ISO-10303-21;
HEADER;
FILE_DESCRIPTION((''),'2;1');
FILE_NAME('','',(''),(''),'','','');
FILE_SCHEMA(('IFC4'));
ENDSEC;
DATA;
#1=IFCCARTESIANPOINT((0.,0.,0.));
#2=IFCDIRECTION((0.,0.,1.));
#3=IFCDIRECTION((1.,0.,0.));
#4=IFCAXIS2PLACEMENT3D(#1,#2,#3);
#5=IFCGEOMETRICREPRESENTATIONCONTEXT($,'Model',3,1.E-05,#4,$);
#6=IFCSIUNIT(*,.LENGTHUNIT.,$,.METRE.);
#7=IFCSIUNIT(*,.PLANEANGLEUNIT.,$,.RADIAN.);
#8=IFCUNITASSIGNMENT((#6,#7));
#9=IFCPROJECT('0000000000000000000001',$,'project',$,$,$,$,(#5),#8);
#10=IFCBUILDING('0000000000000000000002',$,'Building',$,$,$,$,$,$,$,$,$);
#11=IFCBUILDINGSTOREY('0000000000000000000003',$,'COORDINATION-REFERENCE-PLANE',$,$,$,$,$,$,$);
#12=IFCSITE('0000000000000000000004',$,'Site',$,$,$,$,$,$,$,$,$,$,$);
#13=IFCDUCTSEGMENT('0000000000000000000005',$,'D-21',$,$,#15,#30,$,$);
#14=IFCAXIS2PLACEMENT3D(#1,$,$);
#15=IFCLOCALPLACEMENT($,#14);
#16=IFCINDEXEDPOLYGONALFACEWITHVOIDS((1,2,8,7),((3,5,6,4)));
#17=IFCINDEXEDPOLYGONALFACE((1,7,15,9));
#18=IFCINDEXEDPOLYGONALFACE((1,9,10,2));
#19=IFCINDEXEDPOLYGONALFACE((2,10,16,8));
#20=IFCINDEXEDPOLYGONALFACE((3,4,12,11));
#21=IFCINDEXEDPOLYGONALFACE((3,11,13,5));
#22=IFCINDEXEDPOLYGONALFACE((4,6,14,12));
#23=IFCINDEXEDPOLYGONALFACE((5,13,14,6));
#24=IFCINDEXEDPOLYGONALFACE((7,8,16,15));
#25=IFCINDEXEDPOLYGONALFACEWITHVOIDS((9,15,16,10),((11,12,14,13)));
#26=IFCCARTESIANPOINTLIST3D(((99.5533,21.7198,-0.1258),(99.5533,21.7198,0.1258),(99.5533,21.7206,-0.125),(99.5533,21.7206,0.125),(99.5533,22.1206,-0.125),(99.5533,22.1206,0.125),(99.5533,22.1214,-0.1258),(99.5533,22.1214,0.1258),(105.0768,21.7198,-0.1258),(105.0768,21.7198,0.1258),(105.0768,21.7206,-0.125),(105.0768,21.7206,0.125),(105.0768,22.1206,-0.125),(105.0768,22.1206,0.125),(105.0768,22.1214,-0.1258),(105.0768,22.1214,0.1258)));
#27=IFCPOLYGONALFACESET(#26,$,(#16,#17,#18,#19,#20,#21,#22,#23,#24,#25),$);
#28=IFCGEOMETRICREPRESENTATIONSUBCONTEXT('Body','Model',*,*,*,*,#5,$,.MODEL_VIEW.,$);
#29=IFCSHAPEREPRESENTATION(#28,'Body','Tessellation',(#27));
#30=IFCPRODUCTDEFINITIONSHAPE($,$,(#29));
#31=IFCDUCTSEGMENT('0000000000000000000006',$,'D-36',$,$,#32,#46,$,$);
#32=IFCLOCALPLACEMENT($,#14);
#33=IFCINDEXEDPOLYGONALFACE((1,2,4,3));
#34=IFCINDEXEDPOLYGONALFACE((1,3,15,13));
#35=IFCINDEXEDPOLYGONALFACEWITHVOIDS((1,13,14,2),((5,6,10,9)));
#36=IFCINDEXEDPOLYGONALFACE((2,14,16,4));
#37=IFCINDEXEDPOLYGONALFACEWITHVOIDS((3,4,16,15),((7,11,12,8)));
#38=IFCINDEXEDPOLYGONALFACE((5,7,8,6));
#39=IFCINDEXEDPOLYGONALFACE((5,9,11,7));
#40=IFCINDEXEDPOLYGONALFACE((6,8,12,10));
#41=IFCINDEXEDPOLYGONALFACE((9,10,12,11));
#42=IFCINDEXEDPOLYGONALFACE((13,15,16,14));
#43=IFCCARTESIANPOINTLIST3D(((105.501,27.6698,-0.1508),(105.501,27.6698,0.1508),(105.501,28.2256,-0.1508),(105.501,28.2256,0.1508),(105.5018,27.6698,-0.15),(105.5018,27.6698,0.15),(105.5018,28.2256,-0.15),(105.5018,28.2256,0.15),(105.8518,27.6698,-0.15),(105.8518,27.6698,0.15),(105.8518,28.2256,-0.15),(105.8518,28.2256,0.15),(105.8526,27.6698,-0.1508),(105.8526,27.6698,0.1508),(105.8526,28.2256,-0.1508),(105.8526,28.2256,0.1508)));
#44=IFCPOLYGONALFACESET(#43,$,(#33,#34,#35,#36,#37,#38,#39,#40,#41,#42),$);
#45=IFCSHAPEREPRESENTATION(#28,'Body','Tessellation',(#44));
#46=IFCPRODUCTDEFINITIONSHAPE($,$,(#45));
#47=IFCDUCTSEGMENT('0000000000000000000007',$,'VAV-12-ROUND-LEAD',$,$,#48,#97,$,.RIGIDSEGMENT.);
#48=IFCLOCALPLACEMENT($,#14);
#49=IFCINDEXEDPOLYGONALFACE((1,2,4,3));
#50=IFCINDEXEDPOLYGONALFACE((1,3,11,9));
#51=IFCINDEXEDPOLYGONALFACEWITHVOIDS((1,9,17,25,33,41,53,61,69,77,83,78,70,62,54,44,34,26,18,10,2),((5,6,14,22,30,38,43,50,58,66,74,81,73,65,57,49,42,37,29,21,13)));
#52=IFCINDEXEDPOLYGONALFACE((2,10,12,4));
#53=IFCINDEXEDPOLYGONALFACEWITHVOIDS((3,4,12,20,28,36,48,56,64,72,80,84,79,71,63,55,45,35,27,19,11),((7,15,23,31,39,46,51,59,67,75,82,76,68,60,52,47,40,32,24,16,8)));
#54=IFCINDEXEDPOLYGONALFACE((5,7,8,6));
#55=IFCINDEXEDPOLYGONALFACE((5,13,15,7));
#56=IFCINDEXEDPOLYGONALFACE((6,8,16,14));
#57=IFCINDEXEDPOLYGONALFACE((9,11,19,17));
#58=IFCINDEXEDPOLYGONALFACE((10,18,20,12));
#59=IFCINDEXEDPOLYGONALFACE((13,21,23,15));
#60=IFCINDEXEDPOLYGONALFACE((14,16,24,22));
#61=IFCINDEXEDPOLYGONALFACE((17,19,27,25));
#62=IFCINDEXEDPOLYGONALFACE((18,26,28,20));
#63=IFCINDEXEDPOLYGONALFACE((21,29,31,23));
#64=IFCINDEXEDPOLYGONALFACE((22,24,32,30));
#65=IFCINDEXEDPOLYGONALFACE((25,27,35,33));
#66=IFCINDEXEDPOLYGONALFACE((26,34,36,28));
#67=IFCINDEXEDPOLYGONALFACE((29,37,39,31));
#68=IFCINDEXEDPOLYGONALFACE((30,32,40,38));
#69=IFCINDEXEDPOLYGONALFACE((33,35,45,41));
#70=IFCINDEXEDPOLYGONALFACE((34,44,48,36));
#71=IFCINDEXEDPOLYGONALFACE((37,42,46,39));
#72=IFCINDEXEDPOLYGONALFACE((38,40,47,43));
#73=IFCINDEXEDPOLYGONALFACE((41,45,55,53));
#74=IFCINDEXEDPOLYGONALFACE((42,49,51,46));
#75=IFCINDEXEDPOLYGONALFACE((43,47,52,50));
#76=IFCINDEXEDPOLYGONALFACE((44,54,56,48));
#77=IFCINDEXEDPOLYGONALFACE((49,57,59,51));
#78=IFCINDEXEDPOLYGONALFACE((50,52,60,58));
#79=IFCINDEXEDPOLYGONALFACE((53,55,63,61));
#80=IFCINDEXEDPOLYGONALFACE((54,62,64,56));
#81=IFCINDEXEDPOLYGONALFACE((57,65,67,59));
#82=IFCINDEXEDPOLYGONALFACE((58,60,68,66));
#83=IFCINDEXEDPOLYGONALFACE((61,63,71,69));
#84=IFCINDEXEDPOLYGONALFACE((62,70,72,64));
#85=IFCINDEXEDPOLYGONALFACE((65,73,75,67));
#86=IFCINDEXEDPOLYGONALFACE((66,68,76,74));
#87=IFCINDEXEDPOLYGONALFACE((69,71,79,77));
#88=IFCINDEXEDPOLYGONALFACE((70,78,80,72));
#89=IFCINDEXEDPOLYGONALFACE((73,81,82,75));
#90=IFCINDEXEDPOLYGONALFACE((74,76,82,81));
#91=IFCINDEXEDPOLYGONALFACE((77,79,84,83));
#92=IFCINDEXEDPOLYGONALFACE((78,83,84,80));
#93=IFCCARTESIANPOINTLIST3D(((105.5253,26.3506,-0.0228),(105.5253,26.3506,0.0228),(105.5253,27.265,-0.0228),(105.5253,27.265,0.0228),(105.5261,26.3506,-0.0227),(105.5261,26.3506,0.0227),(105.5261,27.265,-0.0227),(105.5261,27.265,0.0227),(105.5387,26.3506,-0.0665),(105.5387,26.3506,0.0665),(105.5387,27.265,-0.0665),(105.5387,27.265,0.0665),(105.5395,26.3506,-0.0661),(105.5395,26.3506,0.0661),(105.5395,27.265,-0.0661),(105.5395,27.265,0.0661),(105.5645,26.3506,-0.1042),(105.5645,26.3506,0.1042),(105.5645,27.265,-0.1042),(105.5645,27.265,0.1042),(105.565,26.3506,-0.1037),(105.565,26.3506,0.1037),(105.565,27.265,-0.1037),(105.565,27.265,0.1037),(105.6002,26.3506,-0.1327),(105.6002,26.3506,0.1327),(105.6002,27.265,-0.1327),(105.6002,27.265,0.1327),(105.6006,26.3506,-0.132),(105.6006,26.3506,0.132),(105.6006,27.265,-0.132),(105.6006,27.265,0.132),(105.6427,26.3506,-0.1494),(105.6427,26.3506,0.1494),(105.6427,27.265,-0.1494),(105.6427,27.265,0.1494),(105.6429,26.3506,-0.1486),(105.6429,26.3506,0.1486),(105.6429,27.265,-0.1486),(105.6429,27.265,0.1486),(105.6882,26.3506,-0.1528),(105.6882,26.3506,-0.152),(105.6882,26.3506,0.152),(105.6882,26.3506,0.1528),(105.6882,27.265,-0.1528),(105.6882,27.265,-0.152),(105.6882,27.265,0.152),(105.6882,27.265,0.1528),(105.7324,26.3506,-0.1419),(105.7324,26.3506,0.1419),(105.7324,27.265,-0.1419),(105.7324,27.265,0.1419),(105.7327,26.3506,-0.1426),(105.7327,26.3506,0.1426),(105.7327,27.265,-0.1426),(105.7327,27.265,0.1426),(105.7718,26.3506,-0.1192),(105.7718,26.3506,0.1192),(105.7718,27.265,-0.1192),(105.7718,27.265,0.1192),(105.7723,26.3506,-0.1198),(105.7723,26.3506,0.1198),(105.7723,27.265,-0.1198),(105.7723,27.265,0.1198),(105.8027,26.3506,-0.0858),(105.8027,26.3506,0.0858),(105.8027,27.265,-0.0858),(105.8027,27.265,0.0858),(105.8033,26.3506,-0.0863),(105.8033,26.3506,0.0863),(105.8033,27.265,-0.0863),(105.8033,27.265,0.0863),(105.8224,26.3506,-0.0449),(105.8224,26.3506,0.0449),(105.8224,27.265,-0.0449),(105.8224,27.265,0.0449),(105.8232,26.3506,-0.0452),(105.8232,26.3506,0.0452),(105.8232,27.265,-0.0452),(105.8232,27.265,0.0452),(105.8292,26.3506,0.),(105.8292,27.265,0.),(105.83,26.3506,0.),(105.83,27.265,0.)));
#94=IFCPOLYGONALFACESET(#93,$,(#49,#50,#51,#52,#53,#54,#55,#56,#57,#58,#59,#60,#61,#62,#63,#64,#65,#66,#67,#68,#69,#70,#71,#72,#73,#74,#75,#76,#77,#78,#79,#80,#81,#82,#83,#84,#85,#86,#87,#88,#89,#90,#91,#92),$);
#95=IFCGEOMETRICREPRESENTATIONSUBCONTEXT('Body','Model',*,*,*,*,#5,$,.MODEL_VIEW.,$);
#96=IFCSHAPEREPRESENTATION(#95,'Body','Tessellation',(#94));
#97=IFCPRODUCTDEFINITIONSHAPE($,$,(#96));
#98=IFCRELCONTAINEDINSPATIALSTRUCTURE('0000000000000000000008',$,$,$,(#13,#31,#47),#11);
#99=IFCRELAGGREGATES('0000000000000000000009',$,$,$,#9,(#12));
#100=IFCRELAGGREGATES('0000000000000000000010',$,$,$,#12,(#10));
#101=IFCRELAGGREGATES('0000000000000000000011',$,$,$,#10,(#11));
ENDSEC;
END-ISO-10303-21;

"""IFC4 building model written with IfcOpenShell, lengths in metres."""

from ifc_helpers import new_model, si_unit, frame, origin, origin_with_axes, place, context, subcontext, project, spatial, hollow_rectangle, hollow_circle, extrude, element, save


model = new_model("IFC4")

# Units and contexts
model_context = context("Model", 3, precision=1e-05, world=origin_with_axes())
body_context_1 = subcontext(model_context, "Body", "Model", "MODEL_VIEW")
body_context_2 = subcontext(model_context, "Body", "Model", "MODEL_VIEW")
ifc_project = project(units=[si_unit("LENGTHUNIT", "METRE"), si_unit("PLANEANGLEUNIT", "RADIAN")], contexts=[model_context])

# Site, building, storey
site = spatial("IfcSite", under=ifc_project, Name="Site")
building = spatial("IfcBuilding", under=site, Name="Building")
storey = spatial("IfcBuildingStorey", under=building, Name="COORDINATION-REFERENCE-PLANE")

# Duct segments
duct_segment_1_placement = place(None, frame((99.5533, 21.9206, 0.0), z_axis=(1.0, 0.0, 0.0), x_axis=(0.0, 1.0, 0.0)))
element("IfcDuctSegment", 1, at=duct_segment_1_placement, inside=storey, Name="D-21", context=body_context_1, shape_type="SweptSolid", body=[
    extrude(hollow_rectangle(XDim=0.4016, YDim=0.2516, WallThickness=0.0008), origin(), (0.0, 0.0, 1.0), 5.5234),
])
duct_segment_2_placement = place(None, frame((105.6768, 27.6698, 0.0), z_axis=(0.0, 1.0, 0.0), x_axis=(1.0, 0.0, 0.0)))
element("IfcDuctSegment", 2, at=duct_segment_2_placement, inside=storey, Name="D-36", context=body_context_1, shape_type="SweptSolid", body=[
    extrude(hollow_rectangle(XDim=0.3516, YDim=0.3016, WallThickness=0.0008), origin(), (0.0, 0.0, 1.0), 0.5558),
])
duct_segment_3_placement = place(None, frame((105.6768, 27.265, 0.0), z_axis=(0.0, -1.0, 0.0), x_axis=(1.0, 0.0, 0.0)))
element("IfcDuctSegment", 3, at=duct_segment_3_placement, inside=storey, Name="VAV-12-ROUND-LEAD", PredefinedType="RIGIDSEGMENT", context=body_context_2, shape_type="SweptSolid", body=[
    extrude(hollow_circle(Radius=0.1532, WallThickness=0.0008), origin(), (0.0, 0.0, 1.0), 0.9144),
])

save(model, "model.ifc")
